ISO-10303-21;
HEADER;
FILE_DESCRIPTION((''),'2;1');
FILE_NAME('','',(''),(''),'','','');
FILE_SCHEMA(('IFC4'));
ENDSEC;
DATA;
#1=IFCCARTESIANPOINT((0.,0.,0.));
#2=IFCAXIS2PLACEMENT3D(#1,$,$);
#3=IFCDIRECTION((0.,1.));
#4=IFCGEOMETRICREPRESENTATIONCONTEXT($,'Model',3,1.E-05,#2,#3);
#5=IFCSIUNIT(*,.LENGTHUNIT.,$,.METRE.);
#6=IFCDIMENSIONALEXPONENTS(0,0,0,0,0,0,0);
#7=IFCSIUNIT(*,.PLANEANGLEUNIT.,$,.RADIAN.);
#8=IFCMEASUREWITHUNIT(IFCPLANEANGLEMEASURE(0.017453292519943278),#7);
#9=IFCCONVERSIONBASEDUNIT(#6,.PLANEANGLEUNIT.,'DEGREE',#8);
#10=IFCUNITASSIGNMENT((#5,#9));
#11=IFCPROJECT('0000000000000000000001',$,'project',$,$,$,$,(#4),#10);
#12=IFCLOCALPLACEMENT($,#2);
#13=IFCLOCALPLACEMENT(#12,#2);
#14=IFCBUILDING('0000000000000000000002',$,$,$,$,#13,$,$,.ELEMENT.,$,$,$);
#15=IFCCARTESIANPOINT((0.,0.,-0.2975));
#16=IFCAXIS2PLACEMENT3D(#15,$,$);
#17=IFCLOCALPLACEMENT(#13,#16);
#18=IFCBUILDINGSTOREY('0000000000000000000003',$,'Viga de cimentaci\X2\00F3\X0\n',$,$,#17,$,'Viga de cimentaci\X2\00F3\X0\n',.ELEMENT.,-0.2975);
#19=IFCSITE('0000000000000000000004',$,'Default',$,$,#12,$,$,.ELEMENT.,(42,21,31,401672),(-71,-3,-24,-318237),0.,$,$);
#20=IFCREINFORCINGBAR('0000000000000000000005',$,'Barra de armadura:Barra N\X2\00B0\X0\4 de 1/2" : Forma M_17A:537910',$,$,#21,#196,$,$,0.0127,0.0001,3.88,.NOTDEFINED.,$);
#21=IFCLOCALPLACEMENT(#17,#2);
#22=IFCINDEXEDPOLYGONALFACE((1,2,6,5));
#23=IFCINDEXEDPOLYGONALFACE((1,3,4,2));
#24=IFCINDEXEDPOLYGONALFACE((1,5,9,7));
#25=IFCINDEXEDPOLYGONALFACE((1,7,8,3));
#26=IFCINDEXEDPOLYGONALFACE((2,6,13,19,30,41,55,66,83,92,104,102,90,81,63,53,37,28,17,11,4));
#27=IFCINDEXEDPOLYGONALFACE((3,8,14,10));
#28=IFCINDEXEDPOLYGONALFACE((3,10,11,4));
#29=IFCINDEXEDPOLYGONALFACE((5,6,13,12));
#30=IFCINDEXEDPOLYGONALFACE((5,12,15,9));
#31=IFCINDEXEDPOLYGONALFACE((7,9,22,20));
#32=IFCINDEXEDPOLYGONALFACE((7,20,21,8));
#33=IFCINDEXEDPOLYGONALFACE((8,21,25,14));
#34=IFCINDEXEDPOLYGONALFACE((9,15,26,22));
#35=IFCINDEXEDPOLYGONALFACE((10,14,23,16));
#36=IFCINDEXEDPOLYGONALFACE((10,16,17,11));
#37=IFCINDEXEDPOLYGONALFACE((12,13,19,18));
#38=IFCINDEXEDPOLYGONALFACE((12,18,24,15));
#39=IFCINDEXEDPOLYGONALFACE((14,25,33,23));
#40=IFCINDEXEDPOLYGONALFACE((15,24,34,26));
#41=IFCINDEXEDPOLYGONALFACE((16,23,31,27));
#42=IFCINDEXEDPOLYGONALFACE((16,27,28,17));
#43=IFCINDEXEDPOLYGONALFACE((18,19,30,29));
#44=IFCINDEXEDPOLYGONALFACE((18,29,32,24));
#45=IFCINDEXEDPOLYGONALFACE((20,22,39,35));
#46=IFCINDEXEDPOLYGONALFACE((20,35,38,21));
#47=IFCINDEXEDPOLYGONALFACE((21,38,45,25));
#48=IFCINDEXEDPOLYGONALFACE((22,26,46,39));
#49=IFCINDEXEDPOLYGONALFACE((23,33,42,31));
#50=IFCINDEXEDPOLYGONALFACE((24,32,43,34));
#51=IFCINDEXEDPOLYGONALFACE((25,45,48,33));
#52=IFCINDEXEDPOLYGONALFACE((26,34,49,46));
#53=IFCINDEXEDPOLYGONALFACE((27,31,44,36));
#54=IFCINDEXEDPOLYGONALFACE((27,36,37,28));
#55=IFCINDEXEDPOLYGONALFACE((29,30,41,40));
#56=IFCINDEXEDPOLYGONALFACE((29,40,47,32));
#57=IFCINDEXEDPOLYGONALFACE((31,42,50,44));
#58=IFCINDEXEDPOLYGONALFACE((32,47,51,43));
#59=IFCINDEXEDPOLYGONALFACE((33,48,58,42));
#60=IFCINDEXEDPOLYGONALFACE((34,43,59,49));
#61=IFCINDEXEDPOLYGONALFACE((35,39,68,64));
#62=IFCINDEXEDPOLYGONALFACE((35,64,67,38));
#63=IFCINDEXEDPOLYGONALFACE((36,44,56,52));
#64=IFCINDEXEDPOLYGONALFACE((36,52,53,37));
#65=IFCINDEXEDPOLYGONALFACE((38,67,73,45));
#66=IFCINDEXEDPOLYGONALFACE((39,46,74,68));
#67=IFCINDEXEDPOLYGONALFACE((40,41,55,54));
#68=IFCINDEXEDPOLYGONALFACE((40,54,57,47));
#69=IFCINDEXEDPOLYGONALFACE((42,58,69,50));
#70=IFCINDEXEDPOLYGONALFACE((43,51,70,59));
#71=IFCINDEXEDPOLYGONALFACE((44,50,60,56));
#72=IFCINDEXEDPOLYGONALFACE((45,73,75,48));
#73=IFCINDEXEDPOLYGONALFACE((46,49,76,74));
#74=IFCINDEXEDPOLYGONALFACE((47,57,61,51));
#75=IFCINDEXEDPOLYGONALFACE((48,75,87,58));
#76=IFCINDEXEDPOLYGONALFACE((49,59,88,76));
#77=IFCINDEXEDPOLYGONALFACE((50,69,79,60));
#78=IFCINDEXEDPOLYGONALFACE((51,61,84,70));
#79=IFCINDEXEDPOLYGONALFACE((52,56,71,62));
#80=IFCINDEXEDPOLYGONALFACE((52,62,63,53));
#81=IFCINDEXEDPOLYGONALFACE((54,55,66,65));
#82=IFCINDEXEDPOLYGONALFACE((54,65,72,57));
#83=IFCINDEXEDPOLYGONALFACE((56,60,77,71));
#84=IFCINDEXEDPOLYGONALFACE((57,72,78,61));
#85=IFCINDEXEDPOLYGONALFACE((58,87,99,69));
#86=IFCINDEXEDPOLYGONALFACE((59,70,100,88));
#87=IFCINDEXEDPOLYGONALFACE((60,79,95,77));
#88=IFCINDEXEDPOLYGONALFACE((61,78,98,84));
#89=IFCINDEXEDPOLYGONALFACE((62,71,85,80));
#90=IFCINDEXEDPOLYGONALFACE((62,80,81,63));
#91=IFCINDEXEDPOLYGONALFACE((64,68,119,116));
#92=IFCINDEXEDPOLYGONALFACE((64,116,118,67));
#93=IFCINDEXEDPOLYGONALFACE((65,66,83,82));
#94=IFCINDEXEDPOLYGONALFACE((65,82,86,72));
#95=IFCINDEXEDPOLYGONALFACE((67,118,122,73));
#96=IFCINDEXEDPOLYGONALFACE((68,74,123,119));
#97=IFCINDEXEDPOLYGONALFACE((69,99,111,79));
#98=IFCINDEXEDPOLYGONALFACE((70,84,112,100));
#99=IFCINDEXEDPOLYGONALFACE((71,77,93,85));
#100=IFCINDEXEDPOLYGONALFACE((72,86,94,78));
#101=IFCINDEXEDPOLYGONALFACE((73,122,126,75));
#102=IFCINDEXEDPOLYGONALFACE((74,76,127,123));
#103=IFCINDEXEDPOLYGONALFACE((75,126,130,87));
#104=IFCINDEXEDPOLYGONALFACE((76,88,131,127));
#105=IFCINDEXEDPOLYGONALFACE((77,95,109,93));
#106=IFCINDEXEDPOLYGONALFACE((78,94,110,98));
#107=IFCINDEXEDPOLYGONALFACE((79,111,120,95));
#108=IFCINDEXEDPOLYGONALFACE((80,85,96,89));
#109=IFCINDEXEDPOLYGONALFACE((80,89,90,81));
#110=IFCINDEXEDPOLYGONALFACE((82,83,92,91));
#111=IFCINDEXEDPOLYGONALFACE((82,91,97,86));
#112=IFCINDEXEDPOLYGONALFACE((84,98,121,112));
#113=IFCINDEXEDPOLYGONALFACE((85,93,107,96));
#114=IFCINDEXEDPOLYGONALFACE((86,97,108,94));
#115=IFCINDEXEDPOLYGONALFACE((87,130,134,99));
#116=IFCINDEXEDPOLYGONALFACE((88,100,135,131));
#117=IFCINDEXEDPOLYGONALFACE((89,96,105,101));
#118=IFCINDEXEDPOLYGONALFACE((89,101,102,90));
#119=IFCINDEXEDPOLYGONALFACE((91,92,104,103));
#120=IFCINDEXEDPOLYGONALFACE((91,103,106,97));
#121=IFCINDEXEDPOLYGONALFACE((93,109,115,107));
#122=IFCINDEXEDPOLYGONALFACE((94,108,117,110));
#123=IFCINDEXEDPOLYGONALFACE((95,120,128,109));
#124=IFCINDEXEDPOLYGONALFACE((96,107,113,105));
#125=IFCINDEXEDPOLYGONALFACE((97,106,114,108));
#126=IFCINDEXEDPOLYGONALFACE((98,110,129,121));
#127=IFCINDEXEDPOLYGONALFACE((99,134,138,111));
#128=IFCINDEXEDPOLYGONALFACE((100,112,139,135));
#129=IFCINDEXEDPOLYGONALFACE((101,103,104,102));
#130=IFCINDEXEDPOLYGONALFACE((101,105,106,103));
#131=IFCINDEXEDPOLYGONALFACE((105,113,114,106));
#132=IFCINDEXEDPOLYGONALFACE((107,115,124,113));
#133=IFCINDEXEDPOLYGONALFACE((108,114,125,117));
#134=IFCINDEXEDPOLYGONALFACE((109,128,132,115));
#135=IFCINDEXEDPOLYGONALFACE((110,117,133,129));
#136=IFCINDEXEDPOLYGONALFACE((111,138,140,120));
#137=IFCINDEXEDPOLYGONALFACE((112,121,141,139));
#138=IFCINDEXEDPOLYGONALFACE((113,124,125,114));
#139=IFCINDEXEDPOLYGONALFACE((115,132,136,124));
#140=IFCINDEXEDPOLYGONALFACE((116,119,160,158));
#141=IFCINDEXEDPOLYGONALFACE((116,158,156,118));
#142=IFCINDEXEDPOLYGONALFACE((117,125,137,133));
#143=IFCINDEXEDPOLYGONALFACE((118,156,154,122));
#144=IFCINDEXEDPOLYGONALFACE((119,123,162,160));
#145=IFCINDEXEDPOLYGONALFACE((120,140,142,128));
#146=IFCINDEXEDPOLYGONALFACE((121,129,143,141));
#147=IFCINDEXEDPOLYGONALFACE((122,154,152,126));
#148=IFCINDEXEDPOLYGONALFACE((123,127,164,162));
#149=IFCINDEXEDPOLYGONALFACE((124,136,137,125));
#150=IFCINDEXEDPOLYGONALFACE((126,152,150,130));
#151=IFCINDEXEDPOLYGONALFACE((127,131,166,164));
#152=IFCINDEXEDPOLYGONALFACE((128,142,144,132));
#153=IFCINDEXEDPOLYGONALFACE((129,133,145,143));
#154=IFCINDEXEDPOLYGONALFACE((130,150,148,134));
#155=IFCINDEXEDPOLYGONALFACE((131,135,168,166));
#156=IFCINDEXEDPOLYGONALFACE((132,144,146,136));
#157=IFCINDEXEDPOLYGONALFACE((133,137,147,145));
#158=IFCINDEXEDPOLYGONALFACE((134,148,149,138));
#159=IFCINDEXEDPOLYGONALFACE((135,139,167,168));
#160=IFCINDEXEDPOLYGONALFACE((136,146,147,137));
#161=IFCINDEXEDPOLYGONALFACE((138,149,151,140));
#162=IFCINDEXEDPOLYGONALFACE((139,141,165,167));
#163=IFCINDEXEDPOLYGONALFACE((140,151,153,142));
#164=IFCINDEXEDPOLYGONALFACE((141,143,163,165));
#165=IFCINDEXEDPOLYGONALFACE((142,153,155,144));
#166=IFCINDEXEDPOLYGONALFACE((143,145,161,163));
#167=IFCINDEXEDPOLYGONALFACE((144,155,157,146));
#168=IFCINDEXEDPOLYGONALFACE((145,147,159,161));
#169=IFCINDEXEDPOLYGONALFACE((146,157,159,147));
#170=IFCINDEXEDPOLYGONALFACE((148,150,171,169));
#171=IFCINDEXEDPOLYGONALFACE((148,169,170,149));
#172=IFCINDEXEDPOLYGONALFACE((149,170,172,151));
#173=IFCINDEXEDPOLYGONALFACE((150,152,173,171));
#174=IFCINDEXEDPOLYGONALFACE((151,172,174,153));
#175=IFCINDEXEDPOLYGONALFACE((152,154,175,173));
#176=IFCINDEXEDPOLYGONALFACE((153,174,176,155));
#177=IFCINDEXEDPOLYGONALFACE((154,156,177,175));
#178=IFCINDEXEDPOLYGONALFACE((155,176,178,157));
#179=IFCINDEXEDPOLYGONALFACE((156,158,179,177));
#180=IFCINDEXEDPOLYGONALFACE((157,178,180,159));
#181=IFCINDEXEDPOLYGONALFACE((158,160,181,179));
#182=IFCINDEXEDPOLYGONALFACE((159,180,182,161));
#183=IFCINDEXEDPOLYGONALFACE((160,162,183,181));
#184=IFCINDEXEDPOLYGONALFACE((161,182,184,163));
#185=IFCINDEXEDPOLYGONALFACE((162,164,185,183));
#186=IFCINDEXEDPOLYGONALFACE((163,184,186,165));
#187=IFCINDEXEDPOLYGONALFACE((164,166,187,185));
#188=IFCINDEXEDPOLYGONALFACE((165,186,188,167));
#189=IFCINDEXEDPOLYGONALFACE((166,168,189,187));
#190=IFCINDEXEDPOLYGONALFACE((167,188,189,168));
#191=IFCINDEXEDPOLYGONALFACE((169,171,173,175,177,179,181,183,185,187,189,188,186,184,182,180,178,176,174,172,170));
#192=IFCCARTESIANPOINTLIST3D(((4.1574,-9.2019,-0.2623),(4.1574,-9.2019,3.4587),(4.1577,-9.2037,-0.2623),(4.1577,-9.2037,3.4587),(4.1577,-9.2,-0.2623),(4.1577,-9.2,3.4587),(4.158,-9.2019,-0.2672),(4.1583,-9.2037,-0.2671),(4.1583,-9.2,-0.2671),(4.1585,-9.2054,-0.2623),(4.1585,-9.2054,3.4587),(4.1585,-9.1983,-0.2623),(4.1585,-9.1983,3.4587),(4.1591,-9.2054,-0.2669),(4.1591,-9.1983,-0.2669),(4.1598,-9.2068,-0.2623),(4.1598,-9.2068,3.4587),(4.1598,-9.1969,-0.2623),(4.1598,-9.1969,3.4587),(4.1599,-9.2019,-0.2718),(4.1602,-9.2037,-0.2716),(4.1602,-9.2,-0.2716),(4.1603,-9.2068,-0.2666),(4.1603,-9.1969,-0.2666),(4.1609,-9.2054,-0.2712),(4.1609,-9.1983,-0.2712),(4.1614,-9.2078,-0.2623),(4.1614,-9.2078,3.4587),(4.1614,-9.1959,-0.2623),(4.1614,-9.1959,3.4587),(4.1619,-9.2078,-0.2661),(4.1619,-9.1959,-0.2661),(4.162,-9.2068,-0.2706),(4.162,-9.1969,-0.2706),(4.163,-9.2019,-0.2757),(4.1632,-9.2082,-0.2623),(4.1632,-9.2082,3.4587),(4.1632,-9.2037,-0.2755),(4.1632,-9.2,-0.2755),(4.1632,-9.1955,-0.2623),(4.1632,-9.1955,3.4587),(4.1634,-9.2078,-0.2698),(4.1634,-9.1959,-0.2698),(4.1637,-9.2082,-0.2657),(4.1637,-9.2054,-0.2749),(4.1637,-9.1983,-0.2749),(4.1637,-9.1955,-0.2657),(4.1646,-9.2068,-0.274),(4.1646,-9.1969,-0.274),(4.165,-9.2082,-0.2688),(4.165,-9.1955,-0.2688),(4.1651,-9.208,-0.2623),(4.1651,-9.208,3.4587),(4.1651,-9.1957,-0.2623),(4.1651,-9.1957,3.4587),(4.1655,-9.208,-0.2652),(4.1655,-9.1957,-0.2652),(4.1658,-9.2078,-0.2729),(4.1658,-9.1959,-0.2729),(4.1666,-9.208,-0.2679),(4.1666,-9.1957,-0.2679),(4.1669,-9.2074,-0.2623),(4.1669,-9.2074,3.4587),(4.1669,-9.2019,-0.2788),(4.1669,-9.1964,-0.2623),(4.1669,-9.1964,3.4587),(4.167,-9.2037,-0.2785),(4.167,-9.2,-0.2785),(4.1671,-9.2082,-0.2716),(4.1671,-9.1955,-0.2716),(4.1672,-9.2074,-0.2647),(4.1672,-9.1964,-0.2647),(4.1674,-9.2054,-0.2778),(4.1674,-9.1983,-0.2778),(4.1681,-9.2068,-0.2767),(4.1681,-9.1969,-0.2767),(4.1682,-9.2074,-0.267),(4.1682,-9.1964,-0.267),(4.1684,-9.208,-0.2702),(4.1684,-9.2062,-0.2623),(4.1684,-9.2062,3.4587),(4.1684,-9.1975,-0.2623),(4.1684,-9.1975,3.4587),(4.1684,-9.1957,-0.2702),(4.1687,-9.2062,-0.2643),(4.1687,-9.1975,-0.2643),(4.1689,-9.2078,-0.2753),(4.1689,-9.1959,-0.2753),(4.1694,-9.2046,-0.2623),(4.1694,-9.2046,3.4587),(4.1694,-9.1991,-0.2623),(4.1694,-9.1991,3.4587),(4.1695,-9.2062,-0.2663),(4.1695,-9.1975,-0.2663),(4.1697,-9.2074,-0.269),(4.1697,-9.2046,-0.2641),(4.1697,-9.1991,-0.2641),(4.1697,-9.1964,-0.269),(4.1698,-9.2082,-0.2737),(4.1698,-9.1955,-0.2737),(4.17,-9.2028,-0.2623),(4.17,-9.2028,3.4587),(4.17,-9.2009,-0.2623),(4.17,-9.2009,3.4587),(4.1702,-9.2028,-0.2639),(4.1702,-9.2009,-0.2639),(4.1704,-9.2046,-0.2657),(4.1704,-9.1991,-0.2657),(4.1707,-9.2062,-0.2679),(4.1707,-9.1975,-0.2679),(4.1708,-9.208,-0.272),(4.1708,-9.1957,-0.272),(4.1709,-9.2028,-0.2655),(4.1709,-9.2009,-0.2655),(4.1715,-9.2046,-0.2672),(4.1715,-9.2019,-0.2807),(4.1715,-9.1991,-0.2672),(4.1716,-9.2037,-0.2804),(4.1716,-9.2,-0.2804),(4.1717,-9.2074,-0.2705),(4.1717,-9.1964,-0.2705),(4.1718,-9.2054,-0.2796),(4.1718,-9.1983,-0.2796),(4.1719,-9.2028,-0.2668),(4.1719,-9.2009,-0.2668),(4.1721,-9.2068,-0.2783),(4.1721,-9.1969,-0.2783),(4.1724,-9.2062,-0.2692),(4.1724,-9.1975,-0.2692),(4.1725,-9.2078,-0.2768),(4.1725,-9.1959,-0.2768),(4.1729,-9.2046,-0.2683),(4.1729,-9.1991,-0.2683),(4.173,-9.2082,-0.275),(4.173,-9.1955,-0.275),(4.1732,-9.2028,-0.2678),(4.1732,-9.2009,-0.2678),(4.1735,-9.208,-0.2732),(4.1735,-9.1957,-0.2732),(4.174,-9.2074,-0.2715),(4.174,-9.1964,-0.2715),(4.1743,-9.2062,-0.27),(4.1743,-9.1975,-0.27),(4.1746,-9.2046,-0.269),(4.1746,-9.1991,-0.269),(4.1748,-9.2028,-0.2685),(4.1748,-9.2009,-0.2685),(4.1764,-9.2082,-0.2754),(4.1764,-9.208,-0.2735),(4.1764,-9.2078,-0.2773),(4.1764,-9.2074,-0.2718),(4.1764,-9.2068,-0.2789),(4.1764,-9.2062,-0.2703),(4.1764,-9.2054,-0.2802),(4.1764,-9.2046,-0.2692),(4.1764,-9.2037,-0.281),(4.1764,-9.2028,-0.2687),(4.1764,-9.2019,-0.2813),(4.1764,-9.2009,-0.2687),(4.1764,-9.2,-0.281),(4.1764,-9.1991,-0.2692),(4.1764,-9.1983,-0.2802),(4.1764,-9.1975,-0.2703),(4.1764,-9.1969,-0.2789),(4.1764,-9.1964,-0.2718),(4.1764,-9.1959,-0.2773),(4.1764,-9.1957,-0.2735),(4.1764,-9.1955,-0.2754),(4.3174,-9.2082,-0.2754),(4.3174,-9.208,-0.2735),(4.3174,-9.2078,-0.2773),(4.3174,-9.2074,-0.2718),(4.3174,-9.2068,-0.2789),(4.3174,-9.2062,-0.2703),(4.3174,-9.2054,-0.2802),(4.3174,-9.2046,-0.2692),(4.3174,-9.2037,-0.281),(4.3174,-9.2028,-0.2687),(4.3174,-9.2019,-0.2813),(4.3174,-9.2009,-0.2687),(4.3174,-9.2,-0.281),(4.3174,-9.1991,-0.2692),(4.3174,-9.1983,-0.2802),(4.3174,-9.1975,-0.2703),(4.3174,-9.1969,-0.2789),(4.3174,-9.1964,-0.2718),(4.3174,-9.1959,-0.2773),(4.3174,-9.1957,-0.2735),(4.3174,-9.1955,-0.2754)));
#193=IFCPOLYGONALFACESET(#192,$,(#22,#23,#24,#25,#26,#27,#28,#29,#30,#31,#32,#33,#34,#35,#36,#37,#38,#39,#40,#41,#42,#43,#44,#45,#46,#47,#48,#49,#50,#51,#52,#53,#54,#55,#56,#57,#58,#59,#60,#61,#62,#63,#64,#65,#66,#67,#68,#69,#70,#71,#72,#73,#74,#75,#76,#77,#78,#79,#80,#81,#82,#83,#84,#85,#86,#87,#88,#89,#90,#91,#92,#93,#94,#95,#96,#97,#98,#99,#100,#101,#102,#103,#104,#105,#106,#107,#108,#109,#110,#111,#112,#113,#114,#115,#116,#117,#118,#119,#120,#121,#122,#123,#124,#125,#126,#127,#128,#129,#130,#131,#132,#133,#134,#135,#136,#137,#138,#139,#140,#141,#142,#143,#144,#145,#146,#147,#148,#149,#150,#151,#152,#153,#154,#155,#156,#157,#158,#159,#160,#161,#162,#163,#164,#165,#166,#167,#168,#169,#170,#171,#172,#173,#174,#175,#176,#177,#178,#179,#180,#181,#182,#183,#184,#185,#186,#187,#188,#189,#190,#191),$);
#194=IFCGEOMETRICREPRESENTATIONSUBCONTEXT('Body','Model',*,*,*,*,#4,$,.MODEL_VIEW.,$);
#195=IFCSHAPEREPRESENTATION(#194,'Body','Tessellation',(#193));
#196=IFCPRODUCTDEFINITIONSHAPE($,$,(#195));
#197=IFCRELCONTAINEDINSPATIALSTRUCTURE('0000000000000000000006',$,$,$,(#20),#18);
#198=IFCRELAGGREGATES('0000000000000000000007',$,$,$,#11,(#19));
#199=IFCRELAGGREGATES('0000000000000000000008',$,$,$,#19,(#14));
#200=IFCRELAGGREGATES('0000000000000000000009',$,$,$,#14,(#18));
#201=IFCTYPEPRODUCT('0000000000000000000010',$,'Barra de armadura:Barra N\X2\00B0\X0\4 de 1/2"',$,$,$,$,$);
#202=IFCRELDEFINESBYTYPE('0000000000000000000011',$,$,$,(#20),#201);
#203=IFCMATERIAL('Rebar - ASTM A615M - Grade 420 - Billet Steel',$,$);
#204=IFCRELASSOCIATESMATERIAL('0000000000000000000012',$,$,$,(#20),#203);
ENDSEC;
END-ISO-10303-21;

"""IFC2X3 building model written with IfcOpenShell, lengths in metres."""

from ifc_helpers import new_model, entity, si_unit, converted_unit, direction, frame, origin, place, context, subcontext, project, spatial, material, type_object, element, save


model = new_model("IFC2X3")

# Units and contexts
model_context = context("Model", 3, precision=1e-05, world=origin(), true_north=direction((0.0, 1.0)))
body_context = subcontext(model_context, "Body", "Model", "MODEL_VIEW")
ifc_project = project(units=[si_unit("LENGTHUNIT", "METRE"), converted_unit("PLANEANGLEUNIT", "DEGREE", entity("IfcPlaneAngleMeasure", 0.017453292519943278), si_unit("PLANEANGLEUNIT", "RADIAN"), dimensions=[0, 0, 0, 0, 0, 0, 0])], contexts=[model_context])

# Site, building, storey
site_placement = place(None, origin())
site = spatial("IfcSite", under=ifc_project, at=site_placement, Name="Default", CompositionType="ELEMENT", RefLatitude=(42, 21, 31, 401672), RefLongitude=(-71, -3, -24, -318237), RefElevation=0.0)
building_placement = place(site_placement, origin())
building = spatial("IfcBuilding", under=site, at=building_placement, CompositionType="ELEMENT")
storey_placement = place(building_placement, frame((0.0, 0.0, -0.2975)))
storey = spatial("IfcBuildingStorey", under=building, at=storey_placement, Name="Viga de cimentación", LongName="Viga de cimentación", CompositionType="ELEMENT", Elevation=-0.2975)

# Reinforcing bar
ifc_material = material(Name="Rebar - ASTM A615M - Grade 420 - Billet Steel")
type_product_1 = type_object("IfcTypeProduct", Name="Barra de armadura:Barra N°4 de 1/2\"")
reinforcing_bar_1_placement = place(storey_placement, origin())
element("IfcReinforcingBar", 1, at=reinforcing_bar_1_placement, inside=storey, type_object=type_product_1, material=ifc_material, Name="Barra de armadura:Barra N°4 de 1/2\" : Forma M_17A:537910", BarLength=3.88, BarRole="NOTDEFINED", CrossSectionArea=0.0001, NominalDiameter=0.0127, context=body_context, shape_type="AdvancedSweptSolid", body=[
    entity("IfcSweptDiskSolid", entity("IfcCompositeCurve", [entity("IfcCompositeCurveSegment", "CONTINUOUS", True, entity("IfcPolyline", [entity("IfcCartesianPoint", [4.1637, -9.2019, 3.4587]), entity("IfcCartesianPoint", [4.1637, -9.2019, -0.2623])])), entity("IfcCompositeCurveSegment", "CONTINUOUS", True, entity("IfcTrimmedCurve", entity("IfcCircle", entity("IfcAxis2Placement3D", entity("IfcCartesianPoint", [4.1764, -9.2019, -0.2623]), entity("IfcDirection", [0.0, -1.0, 0.0]), entity("IfcDirection", [0.0, 0.0, -1.0])), 0.0127), [entity("IfcParameterValue", 270.0)], [entity("IfcParameterValue", 360.0)], True, "PARAMETER")), entity("IfcCompositeCurveSegment", "CONTINUOUS", True, entity("IfcPolyline", [entity("IfcCartesianPoint", [4.1764, -9.2019, -0.275]), entity("IfcCartesianPoint", [4.3174, -9.2019, -0.275])]))], False), 0.0063, None, 0.0, 92.0),
])

save(model, "model.ifc")
